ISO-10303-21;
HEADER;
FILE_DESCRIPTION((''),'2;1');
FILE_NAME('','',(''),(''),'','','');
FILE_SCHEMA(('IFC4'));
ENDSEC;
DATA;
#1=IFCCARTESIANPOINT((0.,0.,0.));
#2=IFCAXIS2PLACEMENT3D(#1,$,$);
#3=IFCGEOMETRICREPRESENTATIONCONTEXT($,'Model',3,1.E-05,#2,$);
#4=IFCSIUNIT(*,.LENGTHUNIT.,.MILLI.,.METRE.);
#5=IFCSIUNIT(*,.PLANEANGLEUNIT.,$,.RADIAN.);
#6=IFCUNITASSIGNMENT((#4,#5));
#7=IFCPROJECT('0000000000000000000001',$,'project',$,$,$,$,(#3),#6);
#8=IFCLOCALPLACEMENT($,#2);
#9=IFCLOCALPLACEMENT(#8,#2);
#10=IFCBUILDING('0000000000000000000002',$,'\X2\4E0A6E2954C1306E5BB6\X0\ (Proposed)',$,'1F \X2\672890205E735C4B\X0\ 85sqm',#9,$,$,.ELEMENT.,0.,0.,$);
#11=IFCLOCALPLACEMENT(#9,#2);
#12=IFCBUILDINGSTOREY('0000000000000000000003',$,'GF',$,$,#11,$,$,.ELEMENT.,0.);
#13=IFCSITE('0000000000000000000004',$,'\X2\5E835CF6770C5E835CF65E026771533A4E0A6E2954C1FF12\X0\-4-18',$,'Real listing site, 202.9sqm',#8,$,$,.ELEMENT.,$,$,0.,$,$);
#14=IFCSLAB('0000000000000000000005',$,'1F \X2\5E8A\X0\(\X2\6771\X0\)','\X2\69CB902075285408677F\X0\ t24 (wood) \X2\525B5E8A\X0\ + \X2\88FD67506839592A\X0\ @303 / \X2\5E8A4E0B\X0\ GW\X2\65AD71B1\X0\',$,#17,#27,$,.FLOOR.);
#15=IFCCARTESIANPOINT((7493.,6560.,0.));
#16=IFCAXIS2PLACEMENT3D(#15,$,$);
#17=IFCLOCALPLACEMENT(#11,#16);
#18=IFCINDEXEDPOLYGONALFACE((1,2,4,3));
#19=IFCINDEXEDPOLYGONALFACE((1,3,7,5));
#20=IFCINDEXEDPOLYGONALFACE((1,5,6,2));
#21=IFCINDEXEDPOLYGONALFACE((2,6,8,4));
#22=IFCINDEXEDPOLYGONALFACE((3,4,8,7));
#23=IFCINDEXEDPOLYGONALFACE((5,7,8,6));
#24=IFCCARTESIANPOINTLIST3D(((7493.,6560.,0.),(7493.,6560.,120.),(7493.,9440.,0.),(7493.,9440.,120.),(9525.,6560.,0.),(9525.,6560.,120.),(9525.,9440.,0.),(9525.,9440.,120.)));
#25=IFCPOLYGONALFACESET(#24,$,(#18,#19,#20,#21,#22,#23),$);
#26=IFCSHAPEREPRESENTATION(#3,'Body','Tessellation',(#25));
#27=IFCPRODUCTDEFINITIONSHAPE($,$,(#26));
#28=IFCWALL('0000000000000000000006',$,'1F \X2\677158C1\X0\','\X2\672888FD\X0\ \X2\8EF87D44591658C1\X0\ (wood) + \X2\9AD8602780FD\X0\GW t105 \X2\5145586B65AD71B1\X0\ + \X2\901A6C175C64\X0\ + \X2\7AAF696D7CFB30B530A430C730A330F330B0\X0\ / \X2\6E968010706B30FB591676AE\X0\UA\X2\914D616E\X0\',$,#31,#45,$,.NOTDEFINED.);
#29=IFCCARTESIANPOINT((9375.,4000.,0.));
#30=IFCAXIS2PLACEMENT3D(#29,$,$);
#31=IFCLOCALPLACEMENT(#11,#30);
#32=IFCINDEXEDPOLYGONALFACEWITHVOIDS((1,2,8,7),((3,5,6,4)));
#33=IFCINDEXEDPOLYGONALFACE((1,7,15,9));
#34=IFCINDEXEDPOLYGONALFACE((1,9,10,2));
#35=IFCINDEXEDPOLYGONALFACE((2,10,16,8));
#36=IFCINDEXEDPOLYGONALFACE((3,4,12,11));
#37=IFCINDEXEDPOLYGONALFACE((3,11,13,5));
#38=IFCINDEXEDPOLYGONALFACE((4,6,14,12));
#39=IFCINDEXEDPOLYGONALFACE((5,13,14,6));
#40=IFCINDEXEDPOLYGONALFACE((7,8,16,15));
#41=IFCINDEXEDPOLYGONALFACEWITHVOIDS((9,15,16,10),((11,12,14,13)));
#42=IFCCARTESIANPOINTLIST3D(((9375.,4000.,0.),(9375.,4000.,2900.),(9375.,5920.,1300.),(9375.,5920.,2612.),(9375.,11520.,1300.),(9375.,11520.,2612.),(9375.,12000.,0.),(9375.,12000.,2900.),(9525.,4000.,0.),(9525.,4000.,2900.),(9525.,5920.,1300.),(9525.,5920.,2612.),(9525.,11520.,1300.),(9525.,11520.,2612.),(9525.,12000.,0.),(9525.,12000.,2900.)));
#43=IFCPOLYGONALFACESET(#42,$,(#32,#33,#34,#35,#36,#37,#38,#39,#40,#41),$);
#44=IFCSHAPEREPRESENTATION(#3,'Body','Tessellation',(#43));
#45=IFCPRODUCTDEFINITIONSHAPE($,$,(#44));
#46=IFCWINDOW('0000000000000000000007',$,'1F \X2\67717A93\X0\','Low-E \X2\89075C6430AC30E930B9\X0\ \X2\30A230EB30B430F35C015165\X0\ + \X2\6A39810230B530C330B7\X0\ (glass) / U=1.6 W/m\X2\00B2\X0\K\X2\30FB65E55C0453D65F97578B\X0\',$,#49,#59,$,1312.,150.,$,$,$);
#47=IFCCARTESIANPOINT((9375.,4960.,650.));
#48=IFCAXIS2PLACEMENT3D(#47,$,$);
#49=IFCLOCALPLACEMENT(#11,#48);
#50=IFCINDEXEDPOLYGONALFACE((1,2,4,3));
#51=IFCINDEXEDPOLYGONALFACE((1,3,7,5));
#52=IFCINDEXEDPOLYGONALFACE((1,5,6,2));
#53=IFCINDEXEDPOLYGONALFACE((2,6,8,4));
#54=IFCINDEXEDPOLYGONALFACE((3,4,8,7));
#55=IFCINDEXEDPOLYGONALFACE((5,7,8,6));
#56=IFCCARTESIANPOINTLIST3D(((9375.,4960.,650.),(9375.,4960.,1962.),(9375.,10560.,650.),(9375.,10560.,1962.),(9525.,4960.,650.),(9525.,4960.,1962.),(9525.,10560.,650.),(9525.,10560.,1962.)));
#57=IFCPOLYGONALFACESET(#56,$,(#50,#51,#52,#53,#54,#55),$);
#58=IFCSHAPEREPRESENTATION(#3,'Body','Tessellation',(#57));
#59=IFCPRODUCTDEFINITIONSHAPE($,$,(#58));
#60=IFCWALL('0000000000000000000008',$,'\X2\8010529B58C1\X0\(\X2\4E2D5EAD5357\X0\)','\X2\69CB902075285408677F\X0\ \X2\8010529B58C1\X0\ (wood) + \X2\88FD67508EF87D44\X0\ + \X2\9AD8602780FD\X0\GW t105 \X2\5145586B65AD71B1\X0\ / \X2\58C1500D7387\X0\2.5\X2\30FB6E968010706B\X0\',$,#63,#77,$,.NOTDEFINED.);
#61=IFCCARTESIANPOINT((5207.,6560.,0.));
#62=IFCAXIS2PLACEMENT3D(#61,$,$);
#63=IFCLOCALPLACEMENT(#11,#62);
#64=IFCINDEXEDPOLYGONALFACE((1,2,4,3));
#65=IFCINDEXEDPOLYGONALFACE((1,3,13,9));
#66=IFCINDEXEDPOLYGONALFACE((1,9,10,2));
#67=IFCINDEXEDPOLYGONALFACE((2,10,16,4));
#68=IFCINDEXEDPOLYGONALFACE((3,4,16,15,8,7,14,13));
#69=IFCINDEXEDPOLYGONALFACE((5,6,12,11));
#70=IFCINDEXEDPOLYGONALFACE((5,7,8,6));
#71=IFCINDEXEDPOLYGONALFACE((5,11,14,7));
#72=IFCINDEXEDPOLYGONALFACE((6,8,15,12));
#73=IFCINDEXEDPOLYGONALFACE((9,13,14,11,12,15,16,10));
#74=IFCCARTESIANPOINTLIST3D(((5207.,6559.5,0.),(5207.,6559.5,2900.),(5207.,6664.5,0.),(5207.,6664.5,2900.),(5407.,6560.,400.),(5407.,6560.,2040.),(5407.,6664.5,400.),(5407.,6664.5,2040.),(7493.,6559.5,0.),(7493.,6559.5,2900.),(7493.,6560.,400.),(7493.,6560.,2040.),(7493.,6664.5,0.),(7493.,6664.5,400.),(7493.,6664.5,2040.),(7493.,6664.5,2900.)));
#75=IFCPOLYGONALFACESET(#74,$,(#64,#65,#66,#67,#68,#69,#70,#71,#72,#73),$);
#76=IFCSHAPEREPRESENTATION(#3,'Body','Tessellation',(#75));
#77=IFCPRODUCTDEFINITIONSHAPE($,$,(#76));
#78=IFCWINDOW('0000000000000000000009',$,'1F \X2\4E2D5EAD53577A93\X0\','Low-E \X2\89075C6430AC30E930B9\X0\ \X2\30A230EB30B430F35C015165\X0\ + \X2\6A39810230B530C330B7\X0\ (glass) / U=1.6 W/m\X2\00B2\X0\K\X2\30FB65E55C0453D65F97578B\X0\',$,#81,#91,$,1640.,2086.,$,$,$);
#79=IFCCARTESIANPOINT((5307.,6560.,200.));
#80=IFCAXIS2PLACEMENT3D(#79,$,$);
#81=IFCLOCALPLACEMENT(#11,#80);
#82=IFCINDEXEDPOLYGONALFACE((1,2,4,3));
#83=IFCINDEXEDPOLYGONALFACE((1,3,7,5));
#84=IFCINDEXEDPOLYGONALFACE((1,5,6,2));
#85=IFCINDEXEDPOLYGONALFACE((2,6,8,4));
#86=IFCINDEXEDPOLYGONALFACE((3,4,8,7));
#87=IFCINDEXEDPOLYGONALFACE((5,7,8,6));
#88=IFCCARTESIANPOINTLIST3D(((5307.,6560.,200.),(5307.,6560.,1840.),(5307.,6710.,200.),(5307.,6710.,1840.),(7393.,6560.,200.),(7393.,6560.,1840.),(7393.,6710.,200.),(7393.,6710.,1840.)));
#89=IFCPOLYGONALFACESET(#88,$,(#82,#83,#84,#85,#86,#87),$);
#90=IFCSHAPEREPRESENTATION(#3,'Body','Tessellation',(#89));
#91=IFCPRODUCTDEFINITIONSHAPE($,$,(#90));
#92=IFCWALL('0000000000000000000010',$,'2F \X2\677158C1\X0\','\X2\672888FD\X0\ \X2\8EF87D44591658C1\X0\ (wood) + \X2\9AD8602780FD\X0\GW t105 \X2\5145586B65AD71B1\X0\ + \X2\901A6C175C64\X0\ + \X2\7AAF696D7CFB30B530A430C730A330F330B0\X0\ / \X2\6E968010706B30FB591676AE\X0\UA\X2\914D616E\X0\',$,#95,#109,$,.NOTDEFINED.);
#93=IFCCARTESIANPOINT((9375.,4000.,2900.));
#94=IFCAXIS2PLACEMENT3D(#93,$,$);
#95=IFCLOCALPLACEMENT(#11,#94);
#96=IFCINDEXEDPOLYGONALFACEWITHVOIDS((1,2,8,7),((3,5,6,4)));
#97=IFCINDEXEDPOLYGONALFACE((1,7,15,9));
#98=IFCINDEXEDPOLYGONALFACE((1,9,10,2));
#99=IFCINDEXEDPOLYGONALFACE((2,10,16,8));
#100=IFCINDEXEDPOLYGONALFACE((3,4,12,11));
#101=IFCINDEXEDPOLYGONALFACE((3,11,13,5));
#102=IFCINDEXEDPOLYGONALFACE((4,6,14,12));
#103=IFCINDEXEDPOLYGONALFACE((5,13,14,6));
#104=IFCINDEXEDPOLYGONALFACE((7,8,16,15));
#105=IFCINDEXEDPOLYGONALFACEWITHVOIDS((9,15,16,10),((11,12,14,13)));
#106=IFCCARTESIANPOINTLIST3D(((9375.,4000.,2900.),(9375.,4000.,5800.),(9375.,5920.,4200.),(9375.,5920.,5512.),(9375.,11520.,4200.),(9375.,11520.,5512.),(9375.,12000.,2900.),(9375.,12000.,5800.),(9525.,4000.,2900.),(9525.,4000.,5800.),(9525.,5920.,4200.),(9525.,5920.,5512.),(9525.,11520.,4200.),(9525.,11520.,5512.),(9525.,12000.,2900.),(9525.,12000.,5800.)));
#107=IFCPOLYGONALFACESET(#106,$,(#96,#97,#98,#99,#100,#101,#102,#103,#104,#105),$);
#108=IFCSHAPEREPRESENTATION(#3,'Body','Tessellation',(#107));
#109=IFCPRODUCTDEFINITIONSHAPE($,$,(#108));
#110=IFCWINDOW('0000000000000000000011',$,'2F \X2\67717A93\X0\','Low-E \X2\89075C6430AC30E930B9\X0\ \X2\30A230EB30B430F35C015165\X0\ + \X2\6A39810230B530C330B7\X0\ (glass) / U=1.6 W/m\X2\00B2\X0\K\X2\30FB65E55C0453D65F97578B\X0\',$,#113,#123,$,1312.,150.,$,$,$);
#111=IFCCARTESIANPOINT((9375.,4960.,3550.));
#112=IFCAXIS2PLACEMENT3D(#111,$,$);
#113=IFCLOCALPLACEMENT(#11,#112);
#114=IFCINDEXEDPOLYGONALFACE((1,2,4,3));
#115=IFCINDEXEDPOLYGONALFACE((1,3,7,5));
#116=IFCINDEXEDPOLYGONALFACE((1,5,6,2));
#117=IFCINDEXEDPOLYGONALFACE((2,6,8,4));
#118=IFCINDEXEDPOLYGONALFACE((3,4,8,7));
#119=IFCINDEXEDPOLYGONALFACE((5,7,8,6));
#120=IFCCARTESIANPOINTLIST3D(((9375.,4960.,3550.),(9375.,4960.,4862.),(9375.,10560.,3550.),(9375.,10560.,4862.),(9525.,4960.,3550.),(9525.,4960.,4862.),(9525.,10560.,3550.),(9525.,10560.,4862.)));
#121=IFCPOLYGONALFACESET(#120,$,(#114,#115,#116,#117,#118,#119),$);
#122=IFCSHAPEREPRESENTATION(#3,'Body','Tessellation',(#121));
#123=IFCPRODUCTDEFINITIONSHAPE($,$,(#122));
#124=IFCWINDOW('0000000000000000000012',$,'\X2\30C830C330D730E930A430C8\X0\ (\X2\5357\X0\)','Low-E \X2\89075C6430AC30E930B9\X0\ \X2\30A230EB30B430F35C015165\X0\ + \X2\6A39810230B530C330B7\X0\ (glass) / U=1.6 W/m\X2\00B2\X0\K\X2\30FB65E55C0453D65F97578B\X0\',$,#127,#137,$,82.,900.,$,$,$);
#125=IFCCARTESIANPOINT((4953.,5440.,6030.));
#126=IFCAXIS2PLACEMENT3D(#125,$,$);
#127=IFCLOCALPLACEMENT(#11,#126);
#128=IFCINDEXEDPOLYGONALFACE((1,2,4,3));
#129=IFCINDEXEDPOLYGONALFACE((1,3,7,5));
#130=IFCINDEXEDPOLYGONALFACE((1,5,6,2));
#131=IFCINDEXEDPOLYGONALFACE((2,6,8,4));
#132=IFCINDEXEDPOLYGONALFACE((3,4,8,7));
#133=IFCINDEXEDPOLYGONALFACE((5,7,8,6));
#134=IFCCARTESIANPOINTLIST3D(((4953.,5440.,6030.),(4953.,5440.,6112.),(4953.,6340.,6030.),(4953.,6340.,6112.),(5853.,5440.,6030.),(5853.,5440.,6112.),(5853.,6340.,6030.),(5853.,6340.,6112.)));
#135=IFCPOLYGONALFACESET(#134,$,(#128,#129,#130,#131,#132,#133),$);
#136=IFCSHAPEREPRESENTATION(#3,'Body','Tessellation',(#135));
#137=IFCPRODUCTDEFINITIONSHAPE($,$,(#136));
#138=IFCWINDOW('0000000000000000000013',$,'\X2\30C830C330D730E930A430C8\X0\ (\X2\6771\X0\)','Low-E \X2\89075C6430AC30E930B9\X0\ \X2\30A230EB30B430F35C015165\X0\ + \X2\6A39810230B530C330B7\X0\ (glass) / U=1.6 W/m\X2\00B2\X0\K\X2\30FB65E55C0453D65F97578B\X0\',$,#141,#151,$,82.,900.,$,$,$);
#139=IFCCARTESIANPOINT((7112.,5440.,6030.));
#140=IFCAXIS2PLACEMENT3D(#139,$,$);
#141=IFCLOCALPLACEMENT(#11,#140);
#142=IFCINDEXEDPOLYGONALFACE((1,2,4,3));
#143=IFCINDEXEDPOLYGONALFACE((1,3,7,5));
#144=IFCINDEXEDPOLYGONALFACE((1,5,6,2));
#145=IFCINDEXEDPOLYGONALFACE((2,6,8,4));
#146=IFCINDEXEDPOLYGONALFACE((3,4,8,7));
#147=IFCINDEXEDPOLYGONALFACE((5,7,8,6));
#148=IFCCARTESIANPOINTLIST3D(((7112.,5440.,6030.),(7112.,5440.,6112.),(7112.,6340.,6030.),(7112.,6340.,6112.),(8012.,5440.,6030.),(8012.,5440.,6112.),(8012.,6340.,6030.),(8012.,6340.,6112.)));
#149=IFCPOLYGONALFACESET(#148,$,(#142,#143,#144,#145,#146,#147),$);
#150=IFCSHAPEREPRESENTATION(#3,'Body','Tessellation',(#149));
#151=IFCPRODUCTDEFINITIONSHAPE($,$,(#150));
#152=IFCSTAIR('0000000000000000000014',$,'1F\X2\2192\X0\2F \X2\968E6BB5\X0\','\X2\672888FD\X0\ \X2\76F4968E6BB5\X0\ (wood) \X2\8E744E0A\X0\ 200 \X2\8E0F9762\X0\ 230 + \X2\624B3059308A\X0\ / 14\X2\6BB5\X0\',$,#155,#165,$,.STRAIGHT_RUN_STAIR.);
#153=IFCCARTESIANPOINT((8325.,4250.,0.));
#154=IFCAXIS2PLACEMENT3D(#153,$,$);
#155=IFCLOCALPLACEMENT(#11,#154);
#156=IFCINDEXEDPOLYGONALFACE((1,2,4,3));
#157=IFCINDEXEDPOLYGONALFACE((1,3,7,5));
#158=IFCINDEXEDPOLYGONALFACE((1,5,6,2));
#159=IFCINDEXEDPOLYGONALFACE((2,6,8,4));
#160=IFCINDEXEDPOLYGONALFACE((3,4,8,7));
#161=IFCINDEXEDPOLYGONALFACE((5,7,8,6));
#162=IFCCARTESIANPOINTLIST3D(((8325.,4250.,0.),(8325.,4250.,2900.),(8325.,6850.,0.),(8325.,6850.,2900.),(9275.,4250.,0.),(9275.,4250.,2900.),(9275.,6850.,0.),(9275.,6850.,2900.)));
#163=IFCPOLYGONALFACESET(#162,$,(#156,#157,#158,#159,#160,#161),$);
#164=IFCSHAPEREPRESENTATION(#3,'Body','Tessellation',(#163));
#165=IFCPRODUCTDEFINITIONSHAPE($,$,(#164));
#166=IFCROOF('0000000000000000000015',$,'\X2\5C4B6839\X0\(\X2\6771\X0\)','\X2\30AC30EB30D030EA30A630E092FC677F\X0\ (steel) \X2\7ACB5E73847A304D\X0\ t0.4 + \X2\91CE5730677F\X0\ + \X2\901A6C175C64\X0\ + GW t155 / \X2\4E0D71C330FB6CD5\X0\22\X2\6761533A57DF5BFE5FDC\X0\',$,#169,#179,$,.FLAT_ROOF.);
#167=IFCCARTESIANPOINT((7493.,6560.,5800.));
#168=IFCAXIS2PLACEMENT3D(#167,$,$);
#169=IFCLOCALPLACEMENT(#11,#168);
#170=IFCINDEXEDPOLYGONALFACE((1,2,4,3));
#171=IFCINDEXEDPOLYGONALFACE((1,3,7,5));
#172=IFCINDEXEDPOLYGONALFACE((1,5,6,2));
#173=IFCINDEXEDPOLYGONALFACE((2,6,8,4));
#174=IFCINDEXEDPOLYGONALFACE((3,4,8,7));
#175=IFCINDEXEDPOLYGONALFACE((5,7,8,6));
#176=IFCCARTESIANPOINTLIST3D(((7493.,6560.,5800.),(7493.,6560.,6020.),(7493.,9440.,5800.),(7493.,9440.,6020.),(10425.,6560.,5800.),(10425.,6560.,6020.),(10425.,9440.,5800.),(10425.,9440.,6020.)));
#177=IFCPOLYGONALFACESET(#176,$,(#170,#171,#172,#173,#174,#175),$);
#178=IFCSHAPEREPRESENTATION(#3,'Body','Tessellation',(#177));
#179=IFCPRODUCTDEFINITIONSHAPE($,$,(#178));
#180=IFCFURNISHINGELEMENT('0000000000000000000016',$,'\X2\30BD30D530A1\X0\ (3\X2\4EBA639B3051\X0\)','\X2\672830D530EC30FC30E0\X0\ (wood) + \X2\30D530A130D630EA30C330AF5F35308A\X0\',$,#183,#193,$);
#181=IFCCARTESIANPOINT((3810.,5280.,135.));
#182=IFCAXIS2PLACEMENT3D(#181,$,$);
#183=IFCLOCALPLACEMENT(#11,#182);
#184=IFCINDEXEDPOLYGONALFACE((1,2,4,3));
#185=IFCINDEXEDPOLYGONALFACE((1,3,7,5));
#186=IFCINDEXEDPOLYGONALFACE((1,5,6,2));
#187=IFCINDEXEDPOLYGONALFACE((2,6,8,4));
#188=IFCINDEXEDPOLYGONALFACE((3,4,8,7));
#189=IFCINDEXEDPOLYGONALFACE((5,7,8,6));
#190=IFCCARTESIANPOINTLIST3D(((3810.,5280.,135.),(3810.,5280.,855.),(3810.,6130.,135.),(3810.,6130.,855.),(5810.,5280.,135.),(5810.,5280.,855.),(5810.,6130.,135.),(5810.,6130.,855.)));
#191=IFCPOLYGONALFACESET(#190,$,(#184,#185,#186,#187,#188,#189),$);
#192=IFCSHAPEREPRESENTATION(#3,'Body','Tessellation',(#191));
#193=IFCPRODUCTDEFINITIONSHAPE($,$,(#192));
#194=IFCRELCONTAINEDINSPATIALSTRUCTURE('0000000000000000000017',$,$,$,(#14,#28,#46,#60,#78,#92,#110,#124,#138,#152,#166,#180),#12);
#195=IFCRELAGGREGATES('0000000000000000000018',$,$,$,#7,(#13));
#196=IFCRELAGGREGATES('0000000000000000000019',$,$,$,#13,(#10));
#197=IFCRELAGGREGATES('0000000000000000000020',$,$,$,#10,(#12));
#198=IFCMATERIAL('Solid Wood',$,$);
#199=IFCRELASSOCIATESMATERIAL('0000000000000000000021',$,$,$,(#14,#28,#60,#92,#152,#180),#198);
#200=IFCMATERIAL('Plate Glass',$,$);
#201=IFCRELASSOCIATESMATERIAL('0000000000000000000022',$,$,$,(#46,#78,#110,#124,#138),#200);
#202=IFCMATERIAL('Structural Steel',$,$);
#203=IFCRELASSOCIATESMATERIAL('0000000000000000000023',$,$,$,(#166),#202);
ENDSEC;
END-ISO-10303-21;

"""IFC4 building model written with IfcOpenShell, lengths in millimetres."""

from ifc_helpers import new_model, si_unit, frame, frame_2d, origin, place, context, project, spatial, rectangle, extrude, material, element, fill, save


model = new_model("IFC4")

# Units and contexts
model_context = context("Model", 3, precision=1e-05, world=origin())
ifc_project = project(units=[si_unit("LENGTHUNIT", "METRE", prefix="MILLI"), si_unit("PLANEANGLEUNIT", "RADIAN")], contexts=[model_context])

# Site, building, storey
site_placement = place(None, origin())
site = spatial("IfcSite", under=ifc_project, at=site_placement, Name="広島県広島市東区上温品２-4-18", ObjectType="Real listing site, 202.9sqm", CompositionType="ELEMENT", RefElevation=0.0)
building_placement = place(site_placement, origin())
building = spatial("IfcBuilding", under=site, at=building_placement, Name="上温品の家 (Proposed)", ObjectType="1F 木造平屋 85sqm", CompositionType="ELEMENT", ElevationOfRefHeight=0.0, ElevationOfTerrain=0.0)
storey_placement = place(building_placement, origin())
storey = spatial("IfcBuildingStorey", under=building, at=storey_placement, Name="GF", CompositionType="ELEMENT", Elevation=0.0)

# Slab
ifc_material_1 = material(Name="Solid Wood")
slab_placement = place(storey_placement, frame((7493.0, 6560.0, 0.0)))
element("IfcSlab", 1, at=slab_placement, inside=storey, material=ifc_material_1, Name="1F 床(東)", Description="構造用合板 t24 (wood) 剛床 + 製材根太 @303 / 床下 GW断熱", PredefinedType="FLOOR", context=model_context, shape_type="SweptSolid", body=[
    extrude(rectangle(XDim=2032.0, YDim=2880.0, at=frame_2d((1016.0, 1440.0))), frame((7493.0, 6560.0, 0.0)), (0.0, 0.0, 1.0), 120.0),
])

# Walls, openings, windows
wall_1_placement = place(storey_placement, frame((9375.0, 4000.0, 0.0)))
wall_1 = element("IfcWall", 2, at=wall_1_placement, inside=storey, material=ifc_material_1, Name="1F 東壁", Description="木製 軸組外壁 (wood) + 高性能GW t105 充填断熱 + 通気層 + 窯業系サイディング / 準耐火・外皮UA配慮", PredefinedType="NOTDEFINED", context=model_context, shape_type="SweptSolid", body=[
    extrude(rectangle(XDim=150.0, YDim=8000.0, at=frame_2d((75.0, 4000.0))), frame((9375.0, 4000.0, 0.0)), (0.0, 0.0, 1.0), 2900.0),
])
opening_1_placement = place(storey_placement, frame((9375.0, 4960.0, 650.0)))
opening_1 = element("IfcOpeningElement", 3, at=opening_1_placement, cuts=wall_1, PredefinedType="NOTDEFINED", context=model_context, shape_type="SweptSolid", body=[
    extrude(rectangle(XDim=150.0, YDim=5600.0, at=frame_2d((75.0, 2800.0))), frame((9375.0, 4960.0, 650.0)), (0.0, 0.0, 1.0), 1312.0),
])
ifc_material_2 = material(Name="Plate Glass")
window_1_placement = place(storey_placement, frame((9375.0, 4960.0, 650.0)))
window_1 = element("IfcWindow", 4, at=window_1_placement, inside=storey, material=ifc_material_2, Name="1F 東窓", Description="Low-E 複層ガラス アルゴン封入 + 樹脂サッシ (glass) / U=1.6 W/m²K・日射取得型", OverallHeight=1312.0, OverallWidth=150.0, context=model_context, shape_type="SweptSolid", body=[
    extrude(rectangle(XDim=150.0, YDim=5600.0, at=frame_2d((75.0, 2800.0))), frame((9375.0, 4960.0, 650.0)), (0.0, 0.0, 1.0), 1312.0),
])
fill(opening_1, window_1)
wall_2_placement = place(storey_placement, frame((5207.0, 6560.0, 0.0)))
wall_2 = element("IfcWall", 5, at=wall_2_placement, inside=storey, material=ifc_material_1, Name="耐力壁(中庭南)", Description="構造用合板 耐力壁 (wood) + 製材軸組 + 高性能GW t105 充填断熱 / 壁倍率2.5・準耐火", PredefinedType="NOTDEFINED", context=model_context, shape_type="SweptSolid", body=[
    extrude(rectangle(XDim=2286.0, YDim=105.0, at=frame_2d((1143.0, 52.0))), frame((5207.0, 6560.0, 0.0)), (0.0, 0.0, 1.0), 2900.0),
])
opening_2_placement = place(storey_placement, frame((5307.0, 6560.0, 200.0)))
opening_2 = element("IfcOpeningElement", 6, at=opening_2_placement, cuts=wall_2, PredefinedType="NOTDEFINED", context=model_context, shape_type="SweptSolid", body=[
    extrude(rectangle(XDim=2086.0, YDim=150.0, at=frame_2d((1043.0, 75.0))), frame((5307.0, 6560.0, 200.0)), (0.0, 0.0, 1.0), 1640.0),
])
window_2_placement = place(storey_placement, frame((5307.0, 6560.0, 200.0)))
window_2 = element("IfcWindow", 7, at=window_2_placement, inside=storey, material=ifc_material_2, Name="1F 中庭南窓", Description="Low-E 複層ガラス アルゴン封入 + 樹脂サッシ (glass) / U=1.6 W/m²K・日射取得型", OverallHeight=1640.0, OverallWidth=2086.0, context=model_context, shape_type="SweptSolid", body=[
    extrude(rectangle(XDim=2086.0, YDim=150.0, at=frame_2d((1043.0, 75.0))), frame((5307.0, 6560.0, 200.0)), (0.0, 0.0, 1.0), 1640.0),
])
fill(opening_2, window_2)

# Wall, opening, window
wall_3_placement = place(storey_placement, frame((9375.0, 4000.0, 2900.0)))
wall_3 = element("IfcWall", 8, at=wall_3_placement, inside=storey, material=ifc_material_1, Name="2F 東壁", Description="木製 軸組外壁 (wood) + 高性能GW t105 充填断熱 + 通気層 + 窯業系サイディング / 準耐火・外皮UA配慮", PredefinedType="NOTDEFINED", context=model_context, shape_type="SweptSolid", body=[
    extrude(rectangle(XDim=150.0, YDim=8000.0, at=frame_2d((75.0, 4000.0))), frame((9375.0, 4000.0, 2900.0)), (0.0, 0.0, 1.0), 2900.0),
])
opening_3_placement = place(storey_placement, frame((9375.0, 4960.0, 3550.0)))
opening_3 = element("IfcOpeningElement", 9, at=opening_3_placement, cuts=wall_3, PredefinedType="NOTDEFINED", context=model_context, shape_type="SweptSolid", body=[
    extrude(rectangle(XDim=150.0, YDim=5600.0, at=frame_2d((75.0, 2800.0))), frame((9375.0, 4960.0, 3550.0)), (0.0, 0.0, 1.0), 1312.0),
])
window_3_placement = place(storey_placement, frame((9375.0, 4960.0, 3550.0)))
window_3 = element("IfcWindow", 10, at=window_3_placement, inside=storey, material=ifc_material_2, Name="2F 東窓", Description="Low-E 複層ガラス アルゴン封入 + 樹脂サッシ (glass) / U=1.6 W/m²K・日射取得型", OverallHeight=1312.0, OverallWidth=150.0, context=model_context, shape_type="SweptSolid", body=[
    extrude(rectangle(XDim=150.0, YDim=5600.0, at=frame_2d((75.0, 2800.0))), frame((9375.0, 4960.0, 3550.0)), (0.0, 0.0, 1.0), 1312.0),
])
fill(opening_3, window_3)

# Windows
window_4_placement = place(storey_placement, frame((4953.0, 5440.0, 6030.0)))
element("IfcWindow", 11, at=window_4_placement, inside=storey, material=ifc_material_2, Name="トップライト (南)", Description="Low-E 複層ガラス アルゴン封入 + 樹脂サッシ (glass) / U=1.6 W/m²K・日射取得型", OverallHeight=82.0, OverallWidth=900.0, context=model_context, shape_type="SweptSolid", body=[
    extrude(rectangle(XDim=900.0, YDim=900.0, at=frame_2d((450.0, 450.0))), frame((4953.0, 5440.0, 6030.0)), (0.0, 0.0, 1.0), 82.0),
])
window_5_placement = place(storey_placement, frame((7112.0, 5440.0, 6030.0)))
element("IfcWindow", 12, at=window_5_placement, inside=storey, material=ifc_material_2, Name="トップライト (東)", Description="Low-E 複層ガラス アルゴン封入 + 樹脂サッシ (glass) / U=1.6 W/m²K・日射取得型", OverallHeight=82.0, OverallWidth=900.0, context=model_context, shape_type="SweptSolid", body=[
    extrude(rectangle(XDim=900.0, YDim=900.0, at=frame_2d((450.0, 450.0))), frame((7112.0, 5440.0, 6030.0)), (0.0, 0.0, 1.0), 82.0),
])

# Stair
stair_placement = place(storey_placement, frame((8325.0, 4250.0, 0.0)))
element("IfcStair", 13, at=stair_placement, inside=storey, material=ifc_material_1, Name="1F→2F 階段", Description="木製 直階段 (wood) 蹴上 200 踏面 230 + 手すり / 14段", PredefinedType="STRAIGHT_RUN_STAIR", context=model_context, shape_type="SweptSolid", body=[
    extrude(rectangle(XDim=950.0, YDim=2600.0, at=frame_2d((475.0, 1300.0))), frame((8325.0, 4250.0, 0.0)), (0.0, 0.0, 1.0), 2900.0),
])

# Roof
ifc_material_3 = material(Name="Structural Steel")
roof_placement = place(storey_placement, frame((7493.0, 6560.0, 5800.0)))
element("IfcRoof", 14, at=roof_placement, inside=storey, material=ifc_material_3, Name="屋根(東)", Description="ガルバリウム鋼板 (steel) 立平葺き t0.4 + 野地板 + 通気層 + GW t155 / 不燃・法22条区域対応", PredefinedType="FLAT_ROOF", context=model_context, shape_type="SweptSolid", body=[
    extrude(rectangle(XDim=2932.0, YDim=2880.0, at=frame_2d((1466.0, 1440.0))), frame((7493.0, 6560.0, 5800.0)), (0.0, 0.0, 1.0), 220.0),
])

# Furnishing element
furnishing_1_placement = place(storey_placement, frame((3810.0, 5280.0, 135.0)))
element("IfcFurnishingElement", 15, at=furnishing_1_placement, inside=storey, material=ifc_material_1, Name="ソファ (3人掛け)", Description="木フレーム (wood) + ファブリック張り", context=model_context, shape_type="SweptSolid", body=[
    extrude(rectangle(XDim=2000.0, YDim=850.0, at=frame_2d((1000.0, 425.0))), frame((3810.0, 5280.0, 135.0)), (0.0, 0.0, 1.0), 720.0),
])

save(model, "model.ifc")
